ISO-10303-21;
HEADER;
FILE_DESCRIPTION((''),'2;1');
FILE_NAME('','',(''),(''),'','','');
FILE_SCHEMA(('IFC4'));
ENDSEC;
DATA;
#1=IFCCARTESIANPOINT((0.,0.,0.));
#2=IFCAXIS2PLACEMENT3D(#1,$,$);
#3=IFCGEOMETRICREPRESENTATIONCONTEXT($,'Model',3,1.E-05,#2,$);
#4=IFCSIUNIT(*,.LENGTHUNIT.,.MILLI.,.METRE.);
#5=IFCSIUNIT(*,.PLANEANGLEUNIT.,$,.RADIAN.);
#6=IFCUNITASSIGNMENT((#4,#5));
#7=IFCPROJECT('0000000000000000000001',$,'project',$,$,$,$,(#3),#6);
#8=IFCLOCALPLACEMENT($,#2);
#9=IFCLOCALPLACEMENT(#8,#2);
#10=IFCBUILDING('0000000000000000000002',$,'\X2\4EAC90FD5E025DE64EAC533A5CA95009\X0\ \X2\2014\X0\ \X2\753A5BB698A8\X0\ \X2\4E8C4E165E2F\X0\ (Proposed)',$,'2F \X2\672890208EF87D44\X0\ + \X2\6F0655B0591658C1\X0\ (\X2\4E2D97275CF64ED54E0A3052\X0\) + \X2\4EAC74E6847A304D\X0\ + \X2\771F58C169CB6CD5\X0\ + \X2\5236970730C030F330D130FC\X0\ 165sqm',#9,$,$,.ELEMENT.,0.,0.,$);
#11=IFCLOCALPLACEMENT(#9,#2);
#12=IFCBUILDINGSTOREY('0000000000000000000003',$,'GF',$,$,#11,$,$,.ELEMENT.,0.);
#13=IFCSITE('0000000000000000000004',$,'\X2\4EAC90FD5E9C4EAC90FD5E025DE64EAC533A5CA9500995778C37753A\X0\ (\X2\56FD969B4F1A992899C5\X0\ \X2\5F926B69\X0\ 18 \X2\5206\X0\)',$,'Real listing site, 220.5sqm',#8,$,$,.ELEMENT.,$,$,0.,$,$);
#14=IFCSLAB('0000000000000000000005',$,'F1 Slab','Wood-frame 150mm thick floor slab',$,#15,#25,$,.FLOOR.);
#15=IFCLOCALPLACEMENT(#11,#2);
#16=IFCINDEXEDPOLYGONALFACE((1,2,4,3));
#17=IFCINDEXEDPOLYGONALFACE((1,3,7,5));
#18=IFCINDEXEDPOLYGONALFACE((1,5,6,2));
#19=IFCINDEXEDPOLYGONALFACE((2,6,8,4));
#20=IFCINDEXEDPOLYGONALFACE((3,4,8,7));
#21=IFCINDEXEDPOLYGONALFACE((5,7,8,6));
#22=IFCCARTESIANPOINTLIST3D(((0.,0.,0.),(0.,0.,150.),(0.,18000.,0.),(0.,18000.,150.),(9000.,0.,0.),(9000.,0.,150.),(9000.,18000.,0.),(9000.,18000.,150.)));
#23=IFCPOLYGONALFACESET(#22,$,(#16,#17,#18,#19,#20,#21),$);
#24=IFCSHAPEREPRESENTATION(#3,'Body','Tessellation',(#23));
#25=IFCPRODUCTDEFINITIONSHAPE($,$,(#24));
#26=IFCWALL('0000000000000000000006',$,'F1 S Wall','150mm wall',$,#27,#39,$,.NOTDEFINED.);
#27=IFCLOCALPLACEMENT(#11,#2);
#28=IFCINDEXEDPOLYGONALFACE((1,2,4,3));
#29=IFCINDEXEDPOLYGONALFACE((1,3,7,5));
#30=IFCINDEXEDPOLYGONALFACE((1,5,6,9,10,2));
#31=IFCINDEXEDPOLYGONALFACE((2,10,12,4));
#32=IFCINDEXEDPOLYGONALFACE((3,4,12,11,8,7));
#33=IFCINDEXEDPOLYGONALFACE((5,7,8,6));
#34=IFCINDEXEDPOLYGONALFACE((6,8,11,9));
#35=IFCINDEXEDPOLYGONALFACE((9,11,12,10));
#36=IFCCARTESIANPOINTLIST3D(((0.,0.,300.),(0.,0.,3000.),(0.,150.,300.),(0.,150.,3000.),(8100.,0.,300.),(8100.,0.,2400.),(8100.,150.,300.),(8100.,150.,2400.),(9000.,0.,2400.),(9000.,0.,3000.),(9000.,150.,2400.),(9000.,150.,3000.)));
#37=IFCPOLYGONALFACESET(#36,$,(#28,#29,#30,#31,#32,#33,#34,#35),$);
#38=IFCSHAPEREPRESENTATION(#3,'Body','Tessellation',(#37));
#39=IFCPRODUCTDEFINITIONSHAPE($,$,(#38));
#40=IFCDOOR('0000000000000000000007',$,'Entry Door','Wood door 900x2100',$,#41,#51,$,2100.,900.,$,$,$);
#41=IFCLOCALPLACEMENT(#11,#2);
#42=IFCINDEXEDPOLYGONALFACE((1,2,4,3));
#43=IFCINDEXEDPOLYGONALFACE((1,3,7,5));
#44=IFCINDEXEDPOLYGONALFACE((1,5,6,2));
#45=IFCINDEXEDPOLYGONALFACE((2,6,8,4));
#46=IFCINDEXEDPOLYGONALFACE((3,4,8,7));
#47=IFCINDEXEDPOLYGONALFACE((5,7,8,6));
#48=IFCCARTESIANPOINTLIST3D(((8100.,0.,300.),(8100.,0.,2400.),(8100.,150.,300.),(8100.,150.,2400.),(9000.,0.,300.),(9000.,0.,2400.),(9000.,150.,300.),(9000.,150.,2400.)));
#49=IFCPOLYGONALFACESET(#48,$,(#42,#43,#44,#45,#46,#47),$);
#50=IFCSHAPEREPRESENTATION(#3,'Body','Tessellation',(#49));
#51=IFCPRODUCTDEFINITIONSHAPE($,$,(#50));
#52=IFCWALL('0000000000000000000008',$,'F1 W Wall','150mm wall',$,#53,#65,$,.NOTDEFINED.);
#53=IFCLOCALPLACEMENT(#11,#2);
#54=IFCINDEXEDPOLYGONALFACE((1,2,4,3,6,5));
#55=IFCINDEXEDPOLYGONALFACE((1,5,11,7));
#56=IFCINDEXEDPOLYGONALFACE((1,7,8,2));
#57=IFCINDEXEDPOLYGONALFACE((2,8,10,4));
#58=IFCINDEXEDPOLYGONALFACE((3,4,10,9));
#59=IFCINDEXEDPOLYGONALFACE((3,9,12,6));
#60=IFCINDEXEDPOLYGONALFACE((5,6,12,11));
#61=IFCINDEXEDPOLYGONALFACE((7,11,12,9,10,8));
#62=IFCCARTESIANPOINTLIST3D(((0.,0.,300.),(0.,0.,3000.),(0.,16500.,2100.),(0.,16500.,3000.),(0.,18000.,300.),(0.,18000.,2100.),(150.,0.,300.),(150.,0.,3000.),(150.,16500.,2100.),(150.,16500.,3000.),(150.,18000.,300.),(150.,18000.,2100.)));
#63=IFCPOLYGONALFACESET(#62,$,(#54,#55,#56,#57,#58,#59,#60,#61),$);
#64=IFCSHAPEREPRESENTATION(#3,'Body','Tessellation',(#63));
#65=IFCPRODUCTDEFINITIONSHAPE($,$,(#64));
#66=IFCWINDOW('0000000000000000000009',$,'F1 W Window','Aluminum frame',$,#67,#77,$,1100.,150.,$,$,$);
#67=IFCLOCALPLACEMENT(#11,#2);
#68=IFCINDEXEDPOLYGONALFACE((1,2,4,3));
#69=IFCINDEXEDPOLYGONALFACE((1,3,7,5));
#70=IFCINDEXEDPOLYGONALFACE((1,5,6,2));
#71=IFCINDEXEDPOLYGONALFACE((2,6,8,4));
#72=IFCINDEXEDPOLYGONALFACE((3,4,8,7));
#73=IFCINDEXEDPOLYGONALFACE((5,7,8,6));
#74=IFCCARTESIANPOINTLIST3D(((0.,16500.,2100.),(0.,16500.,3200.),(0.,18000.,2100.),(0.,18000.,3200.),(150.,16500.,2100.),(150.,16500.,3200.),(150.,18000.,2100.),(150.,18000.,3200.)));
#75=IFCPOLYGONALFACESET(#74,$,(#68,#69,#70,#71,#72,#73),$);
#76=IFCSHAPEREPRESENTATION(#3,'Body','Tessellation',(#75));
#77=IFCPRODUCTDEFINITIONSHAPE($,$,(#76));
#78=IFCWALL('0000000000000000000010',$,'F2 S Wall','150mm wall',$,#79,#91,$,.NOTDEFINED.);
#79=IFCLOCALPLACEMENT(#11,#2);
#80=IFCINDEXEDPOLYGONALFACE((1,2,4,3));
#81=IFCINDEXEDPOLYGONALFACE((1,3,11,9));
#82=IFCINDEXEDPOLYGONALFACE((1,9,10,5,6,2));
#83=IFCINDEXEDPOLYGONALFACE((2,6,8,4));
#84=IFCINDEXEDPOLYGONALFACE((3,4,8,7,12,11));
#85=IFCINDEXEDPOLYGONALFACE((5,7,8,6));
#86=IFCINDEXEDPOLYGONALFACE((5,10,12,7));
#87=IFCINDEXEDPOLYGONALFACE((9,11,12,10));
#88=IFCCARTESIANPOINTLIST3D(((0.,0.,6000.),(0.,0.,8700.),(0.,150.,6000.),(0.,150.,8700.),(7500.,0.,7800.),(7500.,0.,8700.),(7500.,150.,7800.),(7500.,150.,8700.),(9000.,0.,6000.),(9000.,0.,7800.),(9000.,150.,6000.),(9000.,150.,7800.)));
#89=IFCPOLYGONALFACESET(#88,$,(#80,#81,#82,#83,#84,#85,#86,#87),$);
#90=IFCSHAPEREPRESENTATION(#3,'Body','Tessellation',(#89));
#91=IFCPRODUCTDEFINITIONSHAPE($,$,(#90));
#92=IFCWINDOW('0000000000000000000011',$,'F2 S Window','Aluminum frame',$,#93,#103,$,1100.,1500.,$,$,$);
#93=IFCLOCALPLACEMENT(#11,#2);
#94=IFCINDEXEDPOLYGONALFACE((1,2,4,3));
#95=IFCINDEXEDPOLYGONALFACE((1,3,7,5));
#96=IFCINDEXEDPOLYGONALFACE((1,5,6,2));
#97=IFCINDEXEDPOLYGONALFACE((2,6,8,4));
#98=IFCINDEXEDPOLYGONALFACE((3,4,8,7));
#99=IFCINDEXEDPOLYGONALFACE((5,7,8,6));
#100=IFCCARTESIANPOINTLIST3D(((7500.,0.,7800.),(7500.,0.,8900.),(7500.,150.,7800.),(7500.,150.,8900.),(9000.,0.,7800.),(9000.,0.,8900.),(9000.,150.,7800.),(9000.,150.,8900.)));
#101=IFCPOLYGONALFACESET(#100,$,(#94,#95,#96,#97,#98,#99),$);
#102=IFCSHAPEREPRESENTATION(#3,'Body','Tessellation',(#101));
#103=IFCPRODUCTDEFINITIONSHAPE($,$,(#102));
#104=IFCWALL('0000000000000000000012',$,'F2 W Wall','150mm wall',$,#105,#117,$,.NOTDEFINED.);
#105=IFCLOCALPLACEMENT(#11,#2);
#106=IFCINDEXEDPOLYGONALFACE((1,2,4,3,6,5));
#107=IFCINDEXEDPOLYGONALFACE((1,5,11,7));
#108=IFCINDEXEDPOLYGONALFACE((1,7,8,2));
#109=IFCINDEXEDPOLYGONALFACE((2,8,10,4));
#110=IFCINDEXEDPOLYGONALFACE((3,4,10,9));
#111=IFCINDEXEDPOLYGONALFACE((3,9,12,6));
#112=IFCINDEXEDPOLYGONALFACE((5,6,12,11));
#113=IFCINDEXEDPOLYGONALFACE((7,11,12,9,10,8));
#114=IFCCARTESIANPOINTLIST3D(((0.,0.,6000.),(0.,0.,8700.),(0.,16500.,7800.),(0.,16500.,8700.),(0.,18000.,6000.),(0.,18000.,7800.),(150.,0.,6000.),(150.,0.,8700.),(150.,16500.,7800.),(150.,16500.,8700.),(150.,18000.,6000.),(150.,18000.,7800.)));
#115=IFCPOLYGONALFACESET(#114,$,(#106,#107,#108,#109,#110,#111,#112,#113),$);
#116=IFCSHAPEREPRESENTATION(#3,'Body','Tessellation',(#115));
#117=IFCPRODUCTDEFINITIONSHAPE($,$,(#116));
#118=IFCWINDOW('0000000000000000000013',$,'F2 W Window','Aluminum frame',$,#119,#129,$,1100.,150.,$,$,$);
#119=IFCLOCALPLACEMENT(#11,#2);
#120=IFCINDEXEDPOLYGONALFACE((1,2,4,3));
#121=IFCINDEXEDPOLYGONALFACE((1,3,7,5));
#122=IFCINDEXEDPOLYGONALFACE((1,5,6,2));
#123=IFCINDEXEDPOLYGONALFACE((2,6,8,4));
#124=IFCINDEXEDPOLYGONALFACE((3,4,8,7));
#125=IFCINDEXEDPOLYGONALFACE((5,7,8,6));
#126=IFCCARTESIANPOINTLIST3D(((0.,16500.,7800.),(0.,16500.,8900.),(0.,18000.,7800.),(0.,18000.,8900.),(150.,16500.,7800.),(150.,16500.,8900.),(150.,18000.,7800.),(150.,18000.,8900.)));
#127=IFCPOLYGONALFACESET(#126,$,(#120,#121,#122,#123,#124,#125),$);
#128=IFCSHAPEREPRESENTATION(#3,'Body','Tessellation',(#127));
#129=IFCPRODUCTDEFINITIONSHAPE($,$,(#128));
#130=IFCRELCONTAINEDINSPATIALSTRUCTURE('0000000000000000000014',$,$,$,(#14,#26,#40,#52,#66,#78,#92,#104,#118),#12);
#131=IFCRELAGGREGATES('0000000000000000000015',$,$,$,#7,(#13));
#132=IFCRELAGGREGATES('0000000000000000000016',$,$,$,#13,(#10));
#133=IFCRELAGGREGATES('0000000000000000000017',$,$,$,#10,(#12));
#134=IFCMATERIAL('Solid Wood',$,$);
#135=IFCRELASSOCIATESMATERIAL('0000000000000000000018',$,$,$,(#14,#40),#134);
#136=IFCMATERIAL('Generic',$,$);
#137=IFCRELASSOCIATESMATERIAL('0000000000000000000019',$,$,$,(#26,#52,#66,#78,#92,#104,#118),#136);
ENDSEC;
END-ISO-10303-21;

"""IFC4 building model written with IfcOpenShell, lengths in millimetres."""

from ifc_helpers import new_model, si_unit, frame, frame_2d, origin, place, context, project, spatial, rectangle, extrude, material, element, fill, save


model = new_model("IFC4")

# Units and contexts
model_context = context("Model", 3, precision=1e-05, world=origin())
ifc_project = project(units=[si_unit("LENGTHUNIT", "METRE", prefix="MILLI"), si_unit("PLANEANGLEUNIT", "RADIAN")], contexts=[model_context])

# Site, building, storey
site_placement = place(None, origin())
site = spatial("IfcSite", under=ifc_project, at=site_placement, Name="京都府京都市左京区岩倉長谷町 (国際会館駅 徒歩 18 分)", ObjectType="Real listing site, 220.5sqm", CompositionType="ELEMENT", RefElevation=0.0)
building_placement = place(site_placement, origin())
building = spatial("IfcBuilding", under=site, at=building_placement, Name="京都市左京区岩倉 — 町家風 二世帯 (Proposed)", ObjectType="2F 木造軸組 + 漆喰外壁 (中霧島仕上げ) + 京瓦葺き + 真壁構法 + 制震ダンパー 165sqm", CompositionType="ELEMENT", ElevationOfRefHeight=0.0, ElevationOfTerrain=0.0)
storey_placement = place(building_placement, origin())
storey = spatial("IfcBuildingStorey", under=building, at=storey_placement, Name="GF", CompositionType="ELEMENT", Elevation=0.0)

# Slab
ifc_material_1 = material(Name="Solid Wood")
slab_1_placement = place(storey_placement, origin())
element("IfcSlab", 1, at=slab_1_placement, inside=storey, material=ifc_material_1, Name="F1 Slab", Description="Wood-frame 150mm thick floor slab", PredefinedType="FLOOR", context=model_context, shape_type="SweptSolid", body=[
    extrude(rectangle(XDim=9000.0, YDim=18000.0, at=frame_2d((4500.0, 9000.0))), origin(), (0.0, 0.0, 1.0), 150.0),
])

# Shared definitions
ifc_material_2 = material(Name="Generic")

# Wall, opening, door
wall_1_placement = place(storey_placement, frame((0.0, 0.0, 150.0)))
wall_1 = element("IfcWall", 2, at=wall_1_placement, inside=storey, material=ifc_material_2, Name="F1 S Wall", Description="150mm wall", PredefinedType="NOTDEFINED", context=model_context, shape_type="SweptSolid", body=[
    extrude(rectangle(XDim=9000.0, YDim=150.0, at=frame_2d((4500.0, 75.0))), frame((0.0, 0.0, 150.0)), (0.0, 0.0, 1.0), 2700.0),
])
opening_1_placement = place(storey_placement, frame((4050.0, 0.0, 150.0)))
opening_1 = element("IfcOpeningElement", 3, at=opening_1_placement, cuts=wall_1, PredefinedType="NOTDEFINED", context=model_context, shape_type="SweptSolid", body=[
    extrude(rectangle(XDim=900.0, YDim=150.0, at=frame_2d((450.0, 75.0))), frame((4050.0, 0.0, 150.0)), (0.0, 0.0, 1.0), 2100.0),
])
door_placement = place(storey_placement, frame((4050.0, 0.0, 150.0)))
door = element("IfcDoor", 4, at=door_placement, inside=storey, material=ifc_material_1, Name="Entry Door", Description="Wood door 900x2100", OverallHeight=2100.0, OverallWidth=900.0, context=model_context, shape_type="SweptSolid", body=[
    extrude(rectangle(XDim=900.0, YDim=150.0, at=frame_2d((450.0, 75.0))), frame((4050.0, 0.0, 150.0)), (0.0, 0.0, 1.0), 2100.0),
])
fill(opening_1, door)

# Walls, openings, windows
wall_2_placement = place(storey_placement, frame((0.0, 0.0, 150.0)))
wall_2 = element("IfcWall", 5, at=wall_2_placement, inside=storey, material=ifc_material_2, Name="F1 W Wall", Description="150mm wall", PredefinedType="NOTDEFINED", context=model_context, shape_type="SweptSolid", body=[
    extrude(rectangle(XDim=150.0, YDim=18000.0, at=frame_2d((75.0, 9000.0))), frame((0.0, 0.0, 150.0)), (0.0, 0.0, 1.0), 2700.0),
])
opening_2_placement = place(storey_placement, frame((0.0, 8250.0, 1050.0)))
opening_2 = element("IfcOpeningElement", 6, at=opening_2_placement, cuts=wall_2, PredefinedType="NOTDEFINED", context=model_context, shape_type="SweptSolid", body=[
    extrude(rectangle(XDim=150.0, YDim=1500.0, at=frame_2d((75.0, 750.0))), frame((0.0, 8250.0, 1050.0)), (0.0, 0.0, 1.0), 1100.0),
])
window_1_placement = place(storey_placement, frame((0.0, 8250.0, 1050.0)))
window_1 = element("IfcWindow", 7, at=window_1_placement, inside=storey, material=ifc_material_2, Name="F1 W Window", Description="Aluminum frame", OverallHeight=1100.0, OverallWidth=150.0, context=model_context, shape_type="SweptSolid", body=[
    extrude(rectangle(XDim=150.0, YDim=1500.0, at=frame_2d((75.0, 750.0))), frame((0.0, 8250.0, 1050.0)), (0.0, 0.0, 1.0), 1100.0),
])
fill(opening_2, window_1)
wall_3_placement = place(storey_placement, frame((0.0, 0.0, 3000.0)))
wall_3 = element("IfcWall", 8, at=wall_3_placement, inside=storey, material=ifc_material_2, Name="F2 S Wall", Description="150mm wall", PredefinedType="NOTDEFINED", context=model_context, shape_type="SweptSolid", body=[
    extrude(rectangle(XDim=9000.0, YDim=150.0, at=frame_2d((4500.0, 75.0))), frame((0.0, 0.0, 3000.0)), (0.0, 0.0, 1.0), 2700.0),
])
opening_3_placement = place(storey_placement, frame((3750.0, 0.0, 3900.0)))
opening_3 = element("IfcOpeningElement", 9, at=opening_3_placement, cuts=wall_3, PredefinedType="NOTDEFINED", context=model_context, shape_type="SweptSolid", body=[
    extrude(rectangle(XDim=1500.0, YDim=150.0, at=frame_2d((750.0, 75.0))), frame((3750.0, 0.0, 3900.0)), (0.0, 0.0, 1.0), 1100.0),
])
window_2_placement = place(storey_placement, frame((3750.0, 0.0, 3900.0)))
window_2 = element("IfcWindow", 10, at=window_2_placement, inside=storey, material=ifc_material_2, Name="F2 S Window", Description="Aluminum frame", OverallHeight=1100.0, OverallWidth=1500.0, context=model_context, shape_type="SweptSolid", body=[
    extrude(rectangle(XDim=1500.0, YDim=150.0, at=frame_2d((750.0, 75.0))), frame((3750.0, 0.0, 3900.0)), (0.0, 0.0, 1.0), 1100.0),
])
fill(opening_3, window_2)
wall_4_placement = place(storey_placement, frame((0.0, 0.0, 3000.0)))
wall_4 = element("IfcWall", 11, at=wall_4_placement, inside=storey, material=ifc_material_2, Name="F2 W Wall", Description="150mm wall", PredefinedType="NOTDEFINED", context=model_context, shape_type="SweptSolid", body=[
    extrude(rectangle(XDim=150.0, YDim=18000.0, at=frame_2d((75.0, 9000.0))), frame((0.0, 0.0, 3000.0)), (0.0, 0.0, 1.0), 2700.0),
])
opening_4_placement = place(storey_placement, frame((0.0, 8250.0, 3900.0)))
opening_4 = element("IfcOpeningElement", 12, at=opening_4_placement, cuts=wall_4, PredefinedType="NOTDEFINED", context=model_context, shape_type="SweptSolid", body=[
    extrude(rectangle(XDim=150.0, YDim=1500.0, at=frame_2d((75.0, 750.0))), frame((0.0, 8250.0, 3900.0)), (0.0, 0.0, 1.0), 1100.0),
])
window_3_placement = place(storey_placement, frame((0.0, 8250.0, 3900.0)))
window_3 = element("IfcWindow", 13, at=window_3_placement, inside=storey, material=ifc_material_2, Name="F2 W Window", Description="Aluminum frame", OverallHeight=1100.0, OverallWidth=150.0, context=model_context, shape_type="SweptSolid", body=[
    extrude(rectangle(XDim=150.0, YDim=1500.0, at=frame_2d((75.0, 750.0))), frame((0.0, 8250.0, 3900.0)), (0.0, 0.0, 1.0), 1100.0),
])
fill(opening_4, window_3)

save(model, "model.ifc")
